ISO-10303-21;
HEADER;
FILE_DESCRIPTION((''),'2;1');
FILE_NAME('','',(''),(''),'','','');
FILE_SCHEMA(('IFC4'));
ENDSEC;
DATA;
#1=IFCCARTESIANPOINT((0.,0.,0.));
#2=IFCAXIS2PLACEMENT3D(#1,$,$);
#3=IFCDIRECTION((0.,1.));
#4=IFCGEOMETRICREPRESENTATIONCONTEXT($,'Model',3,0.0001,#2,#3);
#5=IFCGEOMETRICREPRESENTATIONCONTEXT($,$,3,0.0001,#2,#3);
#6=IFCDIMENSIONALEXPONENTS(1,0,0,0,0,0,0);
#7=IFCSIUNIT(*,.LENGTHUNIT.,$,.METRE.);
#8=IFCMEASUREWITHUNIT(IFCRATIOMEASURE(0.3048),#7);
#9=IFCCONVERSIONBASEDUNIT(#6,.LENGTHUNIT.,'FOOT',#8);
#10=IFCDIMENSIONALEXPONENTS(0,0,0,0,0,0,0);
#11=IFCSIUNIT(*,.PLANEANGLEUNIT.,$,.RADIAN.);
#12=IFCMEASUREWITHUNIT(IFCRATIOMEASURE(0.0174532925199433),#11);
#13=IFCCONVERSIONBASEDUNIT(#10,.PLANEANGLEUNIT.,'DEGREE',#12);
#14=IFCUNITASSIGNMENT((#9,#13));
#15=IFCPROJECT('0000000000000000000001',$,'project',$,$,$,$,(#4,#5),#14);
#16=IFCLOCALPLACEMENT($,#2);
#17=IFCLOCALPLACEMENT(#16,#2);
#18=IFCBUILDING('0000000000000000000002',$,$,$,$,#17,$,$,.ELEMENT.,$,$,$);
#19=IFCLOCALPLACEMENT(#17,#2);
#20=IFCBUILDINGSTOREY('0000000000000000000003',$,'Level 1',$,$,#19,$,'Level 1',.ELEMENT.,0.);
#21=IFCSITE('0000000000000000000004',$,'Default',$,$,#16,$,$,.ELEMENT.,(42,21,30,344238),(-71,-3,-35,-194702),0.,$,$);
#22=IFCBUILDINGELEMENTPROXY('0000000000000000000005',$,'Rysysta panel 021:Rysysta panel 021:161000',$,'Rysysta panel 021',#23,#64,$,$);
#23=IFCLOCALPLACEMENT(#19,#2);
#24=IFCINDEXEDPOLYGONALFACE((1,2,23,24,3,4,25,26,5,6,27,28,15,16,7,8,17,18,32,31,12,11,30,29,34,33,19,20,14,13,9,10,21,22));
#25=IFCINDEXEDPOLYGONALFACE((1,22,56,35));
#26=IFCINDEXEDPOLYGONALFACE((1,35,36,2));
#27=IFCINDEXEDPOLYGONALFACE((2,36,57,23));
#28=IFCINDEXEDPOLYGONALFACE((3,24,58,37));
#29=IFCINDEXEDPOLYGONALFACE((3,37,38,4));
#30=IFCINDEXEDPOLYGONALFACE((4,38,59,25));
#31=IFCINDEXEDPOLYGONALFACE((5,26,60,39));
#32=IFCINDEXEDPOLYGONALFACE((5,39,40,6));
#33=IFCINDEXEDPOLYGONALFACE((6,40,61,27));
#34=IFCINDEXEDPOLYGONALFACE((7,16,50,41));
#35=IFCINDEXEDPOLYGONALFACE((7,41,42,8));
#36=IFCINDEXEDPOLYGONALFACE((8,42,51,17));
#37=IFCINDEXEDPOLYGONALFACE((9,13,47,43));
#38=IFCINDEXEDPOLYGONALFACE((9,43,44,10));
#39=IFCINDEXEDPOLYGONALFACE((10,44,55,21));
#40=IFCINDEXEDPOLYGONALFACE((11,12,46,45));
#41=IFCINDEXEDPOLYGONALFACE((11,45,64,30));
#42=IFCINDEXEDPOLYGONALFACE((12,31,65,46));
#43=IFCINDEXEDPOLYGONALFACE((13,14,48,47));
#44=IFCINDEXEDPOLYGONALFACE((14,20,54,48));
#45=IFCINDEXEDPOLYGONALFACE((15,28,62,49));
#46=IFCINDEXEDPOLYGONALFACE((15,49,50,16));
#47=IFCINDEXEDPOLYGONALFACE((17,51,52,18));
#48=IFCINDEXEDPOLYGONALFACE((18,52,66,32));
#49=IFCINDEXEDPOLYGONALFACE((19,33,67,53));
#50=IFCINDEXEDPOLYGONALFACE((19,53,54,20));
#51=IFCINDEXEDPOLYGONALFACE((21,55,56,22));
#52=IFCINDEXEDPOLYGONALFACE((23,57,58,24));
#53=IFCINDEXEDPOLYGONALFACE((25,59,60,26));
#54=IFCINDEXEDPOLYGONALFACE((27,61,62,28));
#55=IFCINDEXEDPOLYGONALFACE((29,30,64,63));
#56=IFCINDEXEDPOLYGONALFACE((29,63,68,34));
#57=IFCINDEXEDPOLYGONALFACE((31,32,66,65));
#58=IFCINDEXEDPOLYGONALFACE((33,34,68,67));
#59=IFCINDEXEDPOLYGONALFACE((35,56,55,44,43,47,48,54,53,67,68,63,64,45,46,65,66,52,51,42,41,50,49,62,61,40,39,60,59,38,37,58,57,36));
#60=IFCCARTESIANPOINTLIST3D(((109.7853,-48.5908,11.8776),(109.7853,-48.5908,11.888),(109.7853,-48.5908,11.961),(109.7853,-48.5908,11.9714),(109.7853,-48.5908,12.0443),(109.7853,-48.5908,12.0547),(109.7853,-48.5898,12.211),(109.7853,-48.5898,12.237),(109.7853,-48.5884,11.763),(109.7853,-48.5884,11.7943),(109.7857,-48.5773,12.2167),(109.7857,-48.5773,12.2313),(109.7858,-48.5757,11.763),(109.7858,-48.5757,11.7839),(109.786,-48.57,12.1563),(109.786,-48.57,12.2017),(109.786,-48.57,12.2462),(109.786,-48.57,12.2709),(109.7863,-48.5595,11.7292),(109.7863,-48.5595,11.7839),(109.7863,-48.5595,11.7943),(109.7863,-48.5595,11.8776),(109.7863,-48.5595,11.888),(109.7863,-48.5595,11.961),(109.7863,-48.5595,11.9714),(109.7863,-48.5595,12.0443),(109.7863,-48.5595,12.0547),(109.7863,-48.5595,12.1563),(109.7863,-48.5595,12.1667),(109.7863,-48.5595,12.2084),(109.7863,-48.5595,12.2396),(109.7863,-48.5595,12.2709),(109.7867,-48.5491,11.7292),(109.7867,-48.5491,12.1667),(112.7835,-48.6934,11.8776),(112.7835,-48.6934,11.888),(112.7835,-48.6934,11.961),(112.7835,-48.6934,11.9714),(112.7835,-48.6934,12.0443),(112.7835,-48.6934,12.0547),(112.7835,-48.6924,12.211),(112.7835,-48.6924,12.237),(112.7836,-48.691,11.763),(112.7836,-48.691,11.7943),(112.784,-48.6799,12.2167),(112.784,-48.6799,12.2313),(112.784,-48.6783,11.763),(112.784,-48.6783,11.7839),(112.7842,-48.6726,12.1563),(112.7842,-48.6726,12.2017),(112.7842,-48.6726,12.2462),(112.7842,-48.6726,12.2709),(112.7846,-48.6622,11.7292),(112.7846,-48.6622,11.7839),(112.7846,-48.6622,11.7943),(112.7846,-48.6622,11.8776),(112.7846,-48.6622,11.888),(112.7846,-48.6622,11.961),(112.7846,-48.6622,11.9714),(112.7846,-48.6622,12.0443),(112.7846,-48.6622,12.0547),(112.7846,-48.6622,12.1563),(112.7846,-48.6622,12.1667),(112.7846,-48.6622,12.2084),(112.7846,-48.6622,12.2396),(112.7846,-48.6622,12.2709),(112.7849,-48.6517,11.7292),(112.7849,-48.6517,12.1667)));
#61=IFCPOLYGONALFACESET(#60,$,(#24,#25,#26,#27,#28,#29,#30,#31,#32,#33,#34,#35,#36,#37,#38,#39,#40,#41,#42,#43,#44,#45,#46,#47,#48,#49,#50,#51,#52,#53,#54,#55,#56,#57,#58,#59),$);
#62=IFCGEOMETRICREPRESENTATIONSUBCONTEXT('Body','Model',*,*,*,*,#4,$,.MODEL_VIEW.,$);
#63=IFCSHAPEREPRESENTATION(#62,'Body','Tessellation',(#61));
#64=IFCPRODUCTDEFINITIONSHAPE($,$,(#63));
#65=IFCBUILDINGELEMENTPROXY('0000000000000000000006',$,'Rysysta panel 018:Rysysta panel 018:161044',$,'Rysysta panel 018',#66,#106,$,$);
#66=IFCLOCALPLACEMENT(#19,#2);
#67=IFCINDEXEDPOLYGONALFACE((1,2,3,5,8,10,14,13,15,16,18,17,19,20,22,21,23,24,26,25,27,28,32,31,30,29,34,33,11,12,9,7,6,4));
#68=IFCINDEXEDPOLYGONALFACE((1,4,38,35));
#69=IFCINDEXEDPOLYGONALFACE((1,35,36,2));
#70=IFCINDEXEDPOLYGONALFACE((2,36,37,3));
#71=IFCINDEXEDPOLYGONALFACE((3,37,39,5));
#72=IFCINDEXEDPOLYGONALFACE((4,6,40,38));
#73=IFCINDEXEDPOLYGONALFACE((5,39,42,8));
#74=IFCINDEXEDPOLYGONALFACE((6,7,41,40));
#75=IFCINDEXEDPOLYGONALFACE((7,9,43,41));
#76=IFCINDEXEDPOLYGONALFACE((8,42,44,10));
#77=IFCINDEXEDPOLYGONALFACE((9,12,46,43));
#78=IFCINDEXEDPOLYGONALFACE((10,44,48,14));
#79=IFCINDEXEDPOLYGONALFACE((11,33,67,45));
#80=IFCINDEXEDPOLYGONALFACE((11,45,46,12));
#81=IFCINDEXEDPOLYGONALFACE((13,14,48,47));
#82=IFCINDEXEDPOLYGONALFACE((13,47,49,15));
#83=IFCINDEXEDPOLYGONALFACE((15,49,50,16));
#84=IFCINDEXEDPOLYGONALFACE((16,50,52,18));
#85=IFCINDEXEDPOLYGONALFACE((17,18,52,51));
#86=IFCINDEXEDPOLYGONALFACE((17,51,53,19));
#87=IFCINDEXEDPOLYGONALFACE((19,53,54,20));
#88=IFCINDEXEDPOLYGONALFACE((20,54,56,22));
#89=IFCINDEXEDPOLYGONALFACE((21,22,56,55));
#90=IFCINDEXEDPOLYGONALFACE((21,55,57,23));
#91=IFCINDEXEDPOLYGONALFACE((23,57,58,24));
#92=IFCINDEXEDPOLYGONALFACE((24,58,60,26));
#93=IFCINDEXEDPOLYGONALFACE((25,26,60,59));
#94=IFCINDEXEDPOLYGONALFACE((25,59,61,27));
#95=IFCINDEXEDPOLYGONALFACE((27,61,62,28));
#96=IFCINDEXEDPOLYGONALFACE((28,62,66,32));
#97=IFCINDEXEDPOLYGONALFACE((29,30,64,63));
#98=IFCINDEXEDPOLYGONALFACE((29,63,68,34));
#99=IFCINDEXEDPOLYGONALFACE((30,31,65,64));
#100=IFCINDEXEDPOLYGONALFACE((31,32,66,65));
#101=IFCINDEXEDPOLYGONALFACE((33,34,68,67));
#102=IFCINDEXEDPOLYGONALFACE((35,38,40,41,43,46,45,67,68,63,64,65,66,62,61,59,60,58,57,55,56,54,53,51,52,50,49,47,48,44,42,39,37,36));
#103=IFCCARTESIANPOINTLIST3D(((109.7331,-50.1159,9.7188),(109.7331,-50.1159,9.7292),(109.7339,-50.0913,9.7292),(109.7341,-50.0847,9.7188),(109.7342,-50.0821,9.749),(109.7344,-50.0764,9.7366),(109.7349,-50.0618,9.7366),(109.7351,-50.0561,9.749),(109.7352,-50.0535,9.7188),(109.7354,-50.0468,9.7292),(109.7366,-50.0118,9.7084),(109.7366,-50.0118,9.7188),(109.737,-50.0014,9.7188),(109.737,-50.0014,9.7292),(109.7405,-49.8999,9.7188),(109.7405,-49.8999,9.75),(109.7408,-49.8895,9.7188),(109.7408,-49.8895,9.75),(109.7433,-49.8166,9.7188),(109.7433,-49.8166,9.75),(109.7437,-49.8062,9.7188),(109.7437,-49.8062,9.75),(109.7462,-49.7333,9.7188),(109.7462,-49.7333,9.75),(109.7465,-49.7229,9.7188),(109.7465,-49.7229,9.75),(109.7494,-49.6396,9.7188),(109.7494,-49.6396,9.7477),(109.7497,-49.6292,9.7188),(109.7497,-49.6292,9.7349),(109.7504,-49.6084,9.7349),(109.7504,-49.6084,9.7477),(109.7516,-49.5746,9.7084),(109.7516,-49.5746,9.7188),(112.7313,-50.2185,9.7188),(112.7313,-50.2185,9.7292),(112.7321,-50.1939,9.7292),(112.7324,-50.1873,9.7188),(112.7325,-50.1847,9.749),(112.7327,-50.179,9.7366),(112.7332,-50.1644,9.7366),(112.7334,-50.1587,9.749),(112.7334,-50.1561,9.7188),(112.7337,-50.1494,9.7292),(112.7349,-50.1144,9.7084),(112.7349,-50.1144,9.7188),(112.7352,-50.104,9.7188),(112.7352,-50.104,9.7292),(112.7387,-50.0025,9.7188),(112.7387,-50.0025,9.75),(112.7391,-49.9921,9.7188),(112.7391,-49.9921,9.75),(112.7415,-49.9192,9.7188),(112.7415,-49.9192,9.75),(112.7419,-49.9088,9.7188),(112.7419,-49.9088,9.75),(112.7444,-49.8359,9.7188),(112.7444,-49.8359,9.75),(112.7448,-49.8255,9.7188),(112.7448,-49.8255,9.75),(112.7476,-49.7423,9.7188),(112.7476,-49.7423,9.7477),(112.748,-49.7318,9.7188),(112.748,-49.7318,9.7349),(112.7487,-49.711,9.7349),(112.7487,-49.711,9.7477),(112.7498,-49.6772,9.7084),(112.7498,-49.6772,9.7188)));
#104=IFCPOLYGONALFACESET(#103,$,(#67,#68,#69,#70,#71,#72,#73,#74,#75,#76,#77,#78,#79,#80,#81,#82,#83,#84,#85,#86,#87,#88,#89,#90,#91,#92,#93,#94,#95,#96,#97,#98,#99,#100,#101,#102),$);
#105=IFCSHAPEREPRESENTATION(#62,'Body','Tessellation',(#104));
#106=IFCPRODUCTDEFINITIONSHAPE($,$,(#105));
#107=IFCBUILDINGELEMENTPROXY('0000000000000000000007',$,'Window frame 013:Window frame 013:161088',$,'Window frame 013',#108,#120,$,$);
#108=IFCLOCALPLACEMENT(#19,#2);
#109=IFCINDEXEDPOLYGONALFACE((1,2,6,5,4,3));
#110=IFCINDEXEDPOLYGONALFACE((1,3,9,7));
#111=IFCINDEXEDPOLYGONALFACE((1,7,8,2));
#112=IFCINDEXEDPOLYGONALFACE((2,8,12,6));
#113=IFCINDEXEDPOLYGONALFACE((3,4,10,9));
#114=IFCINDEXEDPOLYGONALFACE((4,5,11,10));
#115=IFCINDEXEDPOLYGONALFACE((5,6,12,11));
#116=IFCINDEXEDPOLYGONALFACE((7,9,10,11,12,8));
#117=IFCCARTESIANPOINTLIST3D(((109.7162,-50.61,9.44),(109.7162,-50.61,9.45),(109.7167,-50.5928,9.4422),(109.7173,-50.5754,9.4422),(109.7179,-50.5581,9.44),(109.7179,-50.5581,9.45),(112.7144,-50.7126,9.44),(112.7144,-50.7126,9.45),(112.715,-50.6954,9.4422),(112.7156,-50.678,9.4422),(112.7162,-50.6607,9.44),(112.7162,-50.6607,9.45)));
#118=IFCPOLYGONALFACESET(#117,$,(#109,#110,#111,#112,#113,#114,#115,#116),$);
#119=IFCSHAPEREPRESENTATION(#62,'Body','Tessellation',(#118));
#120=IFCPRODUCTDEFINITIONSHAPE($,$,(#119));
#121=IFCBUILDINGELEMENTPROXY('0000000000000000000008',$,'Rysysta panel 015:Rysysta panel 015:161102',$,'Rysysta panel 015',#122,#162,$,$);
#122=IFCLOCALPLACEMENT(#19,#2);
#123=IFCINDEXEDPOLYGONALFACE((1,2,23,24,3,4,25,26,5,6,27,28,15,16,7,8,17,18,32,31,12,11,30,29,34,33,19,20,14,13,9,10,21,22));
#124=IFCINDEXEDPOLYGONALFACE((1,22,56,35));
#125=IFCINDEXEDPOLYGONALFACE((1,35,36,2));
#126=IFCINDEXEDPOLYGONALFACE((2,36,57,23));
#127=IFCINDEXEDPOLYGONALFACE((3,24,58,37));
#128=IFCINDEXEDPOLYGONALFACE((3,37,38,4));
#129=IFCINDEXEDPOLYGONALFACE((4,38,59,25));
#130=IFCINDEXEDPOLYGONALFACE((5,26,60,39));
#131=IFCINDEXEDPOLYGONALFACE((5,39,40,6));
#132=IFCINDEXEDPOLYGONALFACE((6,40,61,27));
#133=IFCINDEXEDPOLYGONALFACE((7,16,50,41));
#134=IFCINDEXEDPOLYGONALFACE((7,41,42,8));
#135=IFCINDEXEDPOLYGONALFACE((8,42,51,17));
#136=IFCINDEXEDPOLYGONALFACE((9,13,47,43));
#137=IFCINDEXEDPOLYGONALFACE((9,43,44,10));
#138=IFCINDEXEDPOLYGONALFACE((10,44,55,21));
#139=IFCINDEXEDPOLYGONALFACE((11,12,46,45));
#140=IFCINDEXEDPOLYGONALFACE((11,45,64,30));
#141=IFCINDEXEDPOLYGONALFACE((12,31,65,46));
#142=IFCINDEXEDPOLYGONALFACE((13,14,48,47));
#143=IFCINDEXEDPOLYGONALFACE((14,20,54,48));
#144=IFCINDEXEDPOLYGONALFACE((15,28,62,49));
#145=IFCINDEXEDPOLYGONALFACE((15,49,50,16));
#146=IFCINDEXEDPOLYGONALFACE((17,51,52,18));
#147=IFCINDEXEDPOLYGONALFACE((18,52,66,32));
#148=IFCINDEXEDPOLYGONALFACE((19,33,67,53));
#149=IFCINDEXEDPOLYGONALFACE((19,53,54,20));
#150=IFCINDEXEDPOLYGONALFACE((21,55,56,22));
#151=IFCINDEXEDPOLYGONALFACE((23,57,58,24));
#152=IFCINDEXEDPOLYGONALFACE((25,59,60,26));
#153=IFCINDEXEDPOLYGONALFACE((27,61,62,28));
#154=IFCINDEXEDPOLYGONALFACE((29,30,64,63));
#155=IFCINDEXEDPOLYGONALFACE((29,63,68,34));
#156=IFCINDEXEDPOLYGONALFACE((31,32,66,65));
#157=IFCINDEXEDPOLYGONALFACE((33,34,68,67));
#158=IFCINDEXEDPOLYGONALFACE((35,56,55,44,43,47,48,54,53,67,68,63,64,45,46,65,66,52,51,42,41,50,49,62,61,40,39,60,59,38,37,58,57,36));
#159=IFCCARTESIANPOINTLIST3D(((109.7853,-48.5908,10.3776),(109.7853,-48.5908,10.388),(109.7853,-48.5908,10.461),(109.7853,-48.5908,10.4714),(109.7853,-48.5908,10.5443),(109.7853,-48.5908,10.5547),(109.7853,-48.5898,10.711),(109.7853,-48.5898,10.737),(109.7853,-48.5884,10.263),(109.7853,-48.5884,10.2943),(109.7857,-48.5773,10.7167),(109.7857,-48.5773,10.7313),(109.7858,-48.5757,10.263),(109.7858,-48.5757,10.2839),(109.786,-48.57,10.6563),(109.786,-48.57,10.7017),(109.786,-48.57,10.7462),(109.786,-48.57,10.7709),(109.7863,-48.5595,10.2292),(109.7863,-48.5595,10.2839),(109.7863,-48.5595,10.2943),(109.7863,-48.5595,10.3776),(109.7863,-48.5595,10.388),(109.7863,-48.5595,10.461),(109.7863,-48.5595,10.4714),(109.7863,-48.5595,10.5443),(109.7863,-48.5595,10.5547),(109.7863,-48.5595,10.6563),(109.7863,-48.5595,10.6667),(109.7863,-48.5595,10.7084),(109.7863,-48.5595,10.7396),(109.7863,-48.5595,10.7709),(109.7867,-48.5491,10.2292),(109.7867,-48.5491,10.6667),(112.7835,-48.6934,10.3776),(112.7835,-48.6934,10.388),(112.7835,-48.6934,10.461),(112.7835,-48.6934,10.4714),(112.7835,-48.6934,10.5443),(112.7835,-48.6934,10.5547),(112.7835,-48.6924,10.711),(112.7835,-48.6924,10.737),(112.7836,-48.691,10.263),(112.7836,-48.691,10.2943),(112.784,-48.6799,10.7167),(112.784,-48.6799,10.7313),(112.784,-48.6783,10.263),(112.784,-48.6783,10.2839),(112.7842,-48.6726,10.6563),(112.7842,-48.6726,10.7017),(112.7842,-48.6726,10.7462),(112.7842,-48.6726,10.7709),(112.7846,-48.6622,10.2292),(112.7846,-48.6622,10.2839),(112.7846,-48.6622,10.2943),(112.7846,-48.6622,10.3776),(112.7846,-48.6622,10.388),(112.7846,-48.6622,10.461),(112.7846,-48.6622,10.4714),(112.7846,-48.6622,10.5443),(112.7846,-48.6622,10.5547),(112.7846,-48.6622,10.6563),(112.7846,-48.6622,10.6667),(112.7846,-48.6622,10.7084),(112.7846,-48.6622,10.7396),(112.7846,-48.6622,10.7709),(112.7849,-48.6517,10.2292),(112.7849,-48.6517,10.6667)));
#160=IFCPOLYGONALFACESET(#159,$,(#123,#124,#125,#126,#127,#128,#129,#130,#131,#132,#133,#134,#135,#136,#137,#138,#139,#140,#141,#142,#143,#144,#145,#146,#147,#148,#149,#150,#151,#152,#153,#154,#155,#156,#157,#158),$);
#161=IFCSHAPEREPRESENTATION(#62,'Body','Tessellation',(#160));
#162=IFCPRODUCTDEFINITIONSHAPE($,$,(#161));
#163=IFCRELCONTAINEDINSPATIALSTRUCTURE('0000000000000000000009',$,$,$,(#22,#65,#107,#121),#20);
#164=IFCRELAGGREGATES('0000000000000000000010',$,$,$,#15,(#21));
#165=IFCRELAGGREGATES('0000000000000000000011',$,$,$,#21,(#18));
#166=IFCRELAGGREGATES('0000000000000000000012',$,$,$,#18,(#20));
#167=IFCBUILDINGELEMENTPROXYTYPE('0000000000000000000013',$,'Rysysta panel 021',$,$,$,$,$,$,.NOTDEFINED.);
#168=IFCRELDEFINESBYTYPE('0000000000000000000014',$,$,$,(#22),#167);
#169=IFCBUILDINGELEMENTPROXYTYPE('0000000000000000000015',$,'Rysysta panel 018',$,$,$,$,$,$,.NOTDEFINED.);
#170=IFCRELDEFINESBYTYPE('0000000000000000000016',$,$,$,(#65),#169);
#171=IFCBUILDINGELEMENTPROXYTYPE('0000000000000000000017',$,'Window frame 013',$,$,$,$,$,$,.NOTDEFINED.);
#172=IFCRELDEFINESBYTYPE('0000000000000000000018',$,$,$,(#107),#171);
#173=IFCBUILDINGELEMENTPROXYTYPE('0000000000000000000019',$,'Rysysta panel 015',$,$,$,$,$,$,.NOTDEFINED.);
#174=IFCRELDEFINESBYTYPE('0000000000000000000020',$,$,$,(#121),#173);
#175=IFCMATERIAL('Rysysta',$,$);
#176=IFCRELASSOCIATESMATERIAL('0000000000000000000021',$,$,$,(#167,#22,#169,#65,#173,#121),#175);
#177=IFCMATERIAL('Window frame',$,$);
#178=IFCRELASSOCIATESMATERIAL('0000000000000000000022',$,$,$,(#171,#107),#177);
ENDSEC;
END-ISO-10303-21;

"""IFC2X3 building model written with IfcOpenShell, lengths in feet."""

from ifc_helpers import new_model, entity, si_unit, converted_unit, direction, frame, frame_2d, origin, place, context, subcontext, project, spatial, polyline, circle_curve, parameter, trimmed, segment, composite_curve, outline, extrude, source, transform, mapped, material, type_object, type_shapes, element, save


model = new_model("IFC2X3")

# Units and contexts
model_context = context("Model", 3, precision=0.0001, world=origin(), true_north=direction((0.0, 1.0)))
context_of_model = context(None, 3, precision=0.0001, world=origin(), true_north=direction((0.0, 1.0)))
body_context = subcontext(model_context, "Body", "Model", "MODEL_VIEW")
ifc_project = project(units=[converted_unit("LENGTHUNIT", "FOOT", entity("IfcRatioMeasure", 0.3048), si_unit("LENGTHUNIT", "METRE"), dimensions=[1, 0, 0, 0, 0, 0, 0]), converted_unit("PLANEANGLEUNIT", "DEGREE", entity("IfcRatioMeasure", 0.0174532925199433), si_unit("PLANEANGLEUNIT", "RADIAN"), dimensions=[0, 0, 0, 0, 0, 0, 0])], contexts=[model_context, context_of_model])

# Site, building, storey
site_placement = place(None, origin())
site = spatial("IfcSite", under=ifc_project, at=site_placement, Name="Default", CompositionType="ELEMENT", RefLatitude=(42, 21, 30, 344238), RefLongitude=(-71, -3, -35, -194702), RefElevation=0.0)
building_placement = place(site_placement, origin())
building = spatial("IfcBuilding", under=site, at=building_placement, CompositionType="ELEMENT")
storey_placement = place(building_placement, origin())
storey = spatial("IfcBuildingStorey", under=building, at=storey_placement, Name="Level 1", LongName="Level 1", CompositionType="ELEMENT", Elevation=0.0)

# Building element proxies
ifc_material_1 = material(Name="Window frame")
ifc_material_2 = material(Name="Rysysta")
building_element_proxy_type_1 = type_object("IfcBuildingElementProxyType", Name="Rysysta panel 021", PredefinedType="NOTDEFINED", material=ifc_material_2)
shared_shape_1 = source(origin(), body_context, "Body", "SweptSolid", [
    extrude(outline(polyline([(-0.022, 0.1457), (-0.022, -0.2918), (-0.0116, -0.2918), (-0.0116, -0.2371), (0.0045, -0.2371), (0.0045, -0.258), (0.0173, -0.258), (0.0173, -0.2267), (-0.0116, -0.2267), (-0.0116, -0.1434), (0.0196, -0.1434), (0.0196, -0.133), (-0.0116, -0.133), (-0.0116, -0.06), (0.0196, -0.06), (0.0196, -0.0496), (-0.0116, -0.0496), (-0.0116, 0.0233), (0.0196, 0.0233), (0.0196, 0.0337), (-0.0116, 0.0337), (-0.0116, 0.1353), (-0.0012, 0.1353), (-0.0012, 0.1807), (0.0186, 0.1899), (0.0186, 0.216), (-0.0012, 0.2252), (-0.0012, 0.2498), (-0.0116, 0.2498), (-0.0116, 0.2186), (0.0062, 0.2103), (0.0062, 0.1956), (-0.0116, 0.1873), (-0.0116, 0.1457), (-0.022, 0.1457)])), frame((109.7859, -48.5711, 12.021), z_axis=(-0.999415, 0.034202, 0.0), x_axis=(-0.034202, -0.999415, 0.0)), (0.0, 0.0, -1.0), 3.0),
])
type_shapes(building_element_proxy_type_1, [shared_shape_1])
proxy_1_placement = place(storey_placement, origin())
element("IfcBuildingElementProxy", 1, at=proxy_1_placement, inside=storey, type_object=building_element_proxy_type_1, material=ifc_material_2, Name="Rysysta panel 021:Rysysta panel 021:161000", ObjectType="Rysysta panel 021", context=body_context, shape_type="MappedRepresentation", body=[
    mapped(shared_shape_1, transform((0.0, 0.0, 0.0), scale=1.0)),
])
building_element_proxy_type_2 = type_object("IfcBuildingElementProxyType", Name="Rysysta panel 018", PredefinedType="NOTDEFINED", material=ifc_material_2)
shared_shape_2 = source(origin(), body_context, "Body", "SweptSolid", [
    extrude(outline(polyline([(-0.2918, -0.0116), (-0.2918, -0.022), (0.1457, -0.022), (0.1457, -0.0116), (0.1873, -0.0116), (0.1956, 0.0062), (0.2103, 0.0062), (0.2186, -0.0116), (0.2498, -0.0116), (0.2498, -0.0012), (0.2252, -0.0012), (0.216, 0.0186), (0.1899, 0.0186), (0.1807, -0.0012), (0.1353, -0.0012), (0.1353, -0.0116), (0.0337, -0.0116), (0.0337, 0.0196), (0.0233, 0.0196), (0.0233, -0.0116), (-0.0496, -0.0116), (-0.0496, 0.0196), (-0.06, 0.0196), (-0.06, -0.0116), (-0.133, -0.0116), (-0.133, 0.0196), (-0.1434, 0.0196), (-0.1434, -0.0116), (-0.2267, -0.0116), (-0.2267, 0.0173), (-0.258, 0.0173), (-0.258, 0.0045), (-0.2371, 0.0045), (-0.2371, -0.0116), (-0.2918, -0.0116)])), frame((109.7416, -49.8662, 9.7304), z_axis=(-0.999415, 0.034202, 0.0), x_axis=(-0.034202, -0.999415, 0.0)), (0.0, 0.0, -1.0), 3.0),
])
type_shapes(building_element_proxy_type_2, [shared_shape_2])
proxy_2_placement = place(storey_placement, origin())
element("IfcBuildingElementProxy", 2, at=proxy_2_placement, inside=storey, type_object=building_element_proxy_type_2, material=ifc_material_2, Name="Rysysta panel 018:Rysysta panel 018:161044", ObjectType="Rysysta panel 018", context=body_context, shape_type="MappedRepresentation", body=[
    mapped(shared_shape_2, transform((0.0, 0.0, 0.0), scale=1.0)),
])
building_element_proxy_type_3 = type_object("IfcBuildingElementProxyType", Name="Window frame 013", PredefinedType="NOTDEFINED", material=ifc_material_1)
shared_shape_3 = source(origin(), body_context, "Body", "SweptSolid", [
    extrude(outline(composite_curve([segment(polyline([(-0.005, -0.026), (0.005, -0.026)]), True, "CONTINUOUS"), segment(polyline([(0.005, -0.026), (0.005, 0.026)]), True, "CONTINUOUS"), segment(polyline([(0.005, 0.026), (-0.005, 0.026)]), True, "CONTINUOUS"), segment(trimmed(circle_curve(frame_2d((-0.1385, 0.0), x_axis=(0.0, 1.0)), 0.136), [parameter(258.997827)], [parameter(281.002173)], True, "PARAMETER"), False, "CONTINUOUS")], self_intersect=False)), frame((109.717, -50.5841, 9.445), z_axis=(0.999415, -0.034202, 0.0), x_axis=(0.0, 0.0, 1.0)), (0.0, 0.0, 1.0), 3.0),
])
type_shapes(building_element_proxy_type_3, [shared_shape_3])
proxy_3_placement = place(storey_placement, origin())
element("IfcBuildingElementProxy", 3, at=proxy_3_placement, inside=storey, type_object=building_element_proxy_type_3, material=ifc_material_1, Name="Window frame 013:Window frame 013:161088", ObjectType="Window frame 013", context=body_context, shape_type="MappedRepresentation", body=[
    mapped(shared_shape_3, transform((0.0, 0.0, 0.0), scale=1.0)),
])
building_element_proxy_type_4 = type_object("IfcBuildingElementProxyType", Name="Rysysta panel 015", PredefinedType="NOTDEFINED", material=ifc_material_2)
shared_shape_4 = source(origin(), body_context, "Body", "SweptSolid", [
    extrude(outline(polyline([(-0.022, 0.1457), (-0.022, -0.2918), (-0.0116, -0.2918), (-0.0116, -0.2371), (0.0045, -0.2371), (0.0045, -0.258), (0.0173, -0.258), (0.0173, -0.2267), (-0.0116, -0.2267), (-0.0116, -0.1434), (0.0196, -0.1434), (0.0196, -0.133), (-0.0116, -0.133), (-0.0116, -0.06), (0.0196, -0.06), (0.0196, -0.0496), (-0.0116, -0.0496), (-0.0116, 0.0233), (0.0196, 0.0233), (0.0196, 0.0337), (-0.0116, 0.0337), (-0.0116, 0.1353), (-0.0012, 0.1353), (-0.0012, 0.1807), (0.0186, 0.1899), (0.0186, 0.216), (-0.0012, 0.2252), (-0.0012, 0.2498), (-0.0116, 0.2498), (-0.0116, 0.2186), (0.0062, 0.2103), (0.0062, 0.1956), (-0.0116, 0.1873), (-0.0116, 0.1457), (-0.022, 0.1457)])), frame((109.7859, -48.5711, 10.521), z_axis=(-0.999415, 0.034202, 0.0), x_axis=(-0.034202, -0.999415, 0.0)), (0.0, 0.0, -1.0), 3.0),
])
type_shapes(building_element_proxy_type_4, [shared_shape_4])
proxy_4_placement = place(storey_placement, origin())
element("IfcBuildingElementProxy", 4, at=proxy_4_placement, inside=storey, type_object=building_element_proxy_type_4, material=ifc_material_2, Name="Rysysta panel 015:Rysysta panel 015:161102", ObjectType="Rysysta panel 015", context=body_context, shape_type="MappedRepresentation", body=[
    mapped(shared_shape_4, transform((0.0, 0.0, 0.0), scale=1.0)),
])

save(model, "model.ifc")
